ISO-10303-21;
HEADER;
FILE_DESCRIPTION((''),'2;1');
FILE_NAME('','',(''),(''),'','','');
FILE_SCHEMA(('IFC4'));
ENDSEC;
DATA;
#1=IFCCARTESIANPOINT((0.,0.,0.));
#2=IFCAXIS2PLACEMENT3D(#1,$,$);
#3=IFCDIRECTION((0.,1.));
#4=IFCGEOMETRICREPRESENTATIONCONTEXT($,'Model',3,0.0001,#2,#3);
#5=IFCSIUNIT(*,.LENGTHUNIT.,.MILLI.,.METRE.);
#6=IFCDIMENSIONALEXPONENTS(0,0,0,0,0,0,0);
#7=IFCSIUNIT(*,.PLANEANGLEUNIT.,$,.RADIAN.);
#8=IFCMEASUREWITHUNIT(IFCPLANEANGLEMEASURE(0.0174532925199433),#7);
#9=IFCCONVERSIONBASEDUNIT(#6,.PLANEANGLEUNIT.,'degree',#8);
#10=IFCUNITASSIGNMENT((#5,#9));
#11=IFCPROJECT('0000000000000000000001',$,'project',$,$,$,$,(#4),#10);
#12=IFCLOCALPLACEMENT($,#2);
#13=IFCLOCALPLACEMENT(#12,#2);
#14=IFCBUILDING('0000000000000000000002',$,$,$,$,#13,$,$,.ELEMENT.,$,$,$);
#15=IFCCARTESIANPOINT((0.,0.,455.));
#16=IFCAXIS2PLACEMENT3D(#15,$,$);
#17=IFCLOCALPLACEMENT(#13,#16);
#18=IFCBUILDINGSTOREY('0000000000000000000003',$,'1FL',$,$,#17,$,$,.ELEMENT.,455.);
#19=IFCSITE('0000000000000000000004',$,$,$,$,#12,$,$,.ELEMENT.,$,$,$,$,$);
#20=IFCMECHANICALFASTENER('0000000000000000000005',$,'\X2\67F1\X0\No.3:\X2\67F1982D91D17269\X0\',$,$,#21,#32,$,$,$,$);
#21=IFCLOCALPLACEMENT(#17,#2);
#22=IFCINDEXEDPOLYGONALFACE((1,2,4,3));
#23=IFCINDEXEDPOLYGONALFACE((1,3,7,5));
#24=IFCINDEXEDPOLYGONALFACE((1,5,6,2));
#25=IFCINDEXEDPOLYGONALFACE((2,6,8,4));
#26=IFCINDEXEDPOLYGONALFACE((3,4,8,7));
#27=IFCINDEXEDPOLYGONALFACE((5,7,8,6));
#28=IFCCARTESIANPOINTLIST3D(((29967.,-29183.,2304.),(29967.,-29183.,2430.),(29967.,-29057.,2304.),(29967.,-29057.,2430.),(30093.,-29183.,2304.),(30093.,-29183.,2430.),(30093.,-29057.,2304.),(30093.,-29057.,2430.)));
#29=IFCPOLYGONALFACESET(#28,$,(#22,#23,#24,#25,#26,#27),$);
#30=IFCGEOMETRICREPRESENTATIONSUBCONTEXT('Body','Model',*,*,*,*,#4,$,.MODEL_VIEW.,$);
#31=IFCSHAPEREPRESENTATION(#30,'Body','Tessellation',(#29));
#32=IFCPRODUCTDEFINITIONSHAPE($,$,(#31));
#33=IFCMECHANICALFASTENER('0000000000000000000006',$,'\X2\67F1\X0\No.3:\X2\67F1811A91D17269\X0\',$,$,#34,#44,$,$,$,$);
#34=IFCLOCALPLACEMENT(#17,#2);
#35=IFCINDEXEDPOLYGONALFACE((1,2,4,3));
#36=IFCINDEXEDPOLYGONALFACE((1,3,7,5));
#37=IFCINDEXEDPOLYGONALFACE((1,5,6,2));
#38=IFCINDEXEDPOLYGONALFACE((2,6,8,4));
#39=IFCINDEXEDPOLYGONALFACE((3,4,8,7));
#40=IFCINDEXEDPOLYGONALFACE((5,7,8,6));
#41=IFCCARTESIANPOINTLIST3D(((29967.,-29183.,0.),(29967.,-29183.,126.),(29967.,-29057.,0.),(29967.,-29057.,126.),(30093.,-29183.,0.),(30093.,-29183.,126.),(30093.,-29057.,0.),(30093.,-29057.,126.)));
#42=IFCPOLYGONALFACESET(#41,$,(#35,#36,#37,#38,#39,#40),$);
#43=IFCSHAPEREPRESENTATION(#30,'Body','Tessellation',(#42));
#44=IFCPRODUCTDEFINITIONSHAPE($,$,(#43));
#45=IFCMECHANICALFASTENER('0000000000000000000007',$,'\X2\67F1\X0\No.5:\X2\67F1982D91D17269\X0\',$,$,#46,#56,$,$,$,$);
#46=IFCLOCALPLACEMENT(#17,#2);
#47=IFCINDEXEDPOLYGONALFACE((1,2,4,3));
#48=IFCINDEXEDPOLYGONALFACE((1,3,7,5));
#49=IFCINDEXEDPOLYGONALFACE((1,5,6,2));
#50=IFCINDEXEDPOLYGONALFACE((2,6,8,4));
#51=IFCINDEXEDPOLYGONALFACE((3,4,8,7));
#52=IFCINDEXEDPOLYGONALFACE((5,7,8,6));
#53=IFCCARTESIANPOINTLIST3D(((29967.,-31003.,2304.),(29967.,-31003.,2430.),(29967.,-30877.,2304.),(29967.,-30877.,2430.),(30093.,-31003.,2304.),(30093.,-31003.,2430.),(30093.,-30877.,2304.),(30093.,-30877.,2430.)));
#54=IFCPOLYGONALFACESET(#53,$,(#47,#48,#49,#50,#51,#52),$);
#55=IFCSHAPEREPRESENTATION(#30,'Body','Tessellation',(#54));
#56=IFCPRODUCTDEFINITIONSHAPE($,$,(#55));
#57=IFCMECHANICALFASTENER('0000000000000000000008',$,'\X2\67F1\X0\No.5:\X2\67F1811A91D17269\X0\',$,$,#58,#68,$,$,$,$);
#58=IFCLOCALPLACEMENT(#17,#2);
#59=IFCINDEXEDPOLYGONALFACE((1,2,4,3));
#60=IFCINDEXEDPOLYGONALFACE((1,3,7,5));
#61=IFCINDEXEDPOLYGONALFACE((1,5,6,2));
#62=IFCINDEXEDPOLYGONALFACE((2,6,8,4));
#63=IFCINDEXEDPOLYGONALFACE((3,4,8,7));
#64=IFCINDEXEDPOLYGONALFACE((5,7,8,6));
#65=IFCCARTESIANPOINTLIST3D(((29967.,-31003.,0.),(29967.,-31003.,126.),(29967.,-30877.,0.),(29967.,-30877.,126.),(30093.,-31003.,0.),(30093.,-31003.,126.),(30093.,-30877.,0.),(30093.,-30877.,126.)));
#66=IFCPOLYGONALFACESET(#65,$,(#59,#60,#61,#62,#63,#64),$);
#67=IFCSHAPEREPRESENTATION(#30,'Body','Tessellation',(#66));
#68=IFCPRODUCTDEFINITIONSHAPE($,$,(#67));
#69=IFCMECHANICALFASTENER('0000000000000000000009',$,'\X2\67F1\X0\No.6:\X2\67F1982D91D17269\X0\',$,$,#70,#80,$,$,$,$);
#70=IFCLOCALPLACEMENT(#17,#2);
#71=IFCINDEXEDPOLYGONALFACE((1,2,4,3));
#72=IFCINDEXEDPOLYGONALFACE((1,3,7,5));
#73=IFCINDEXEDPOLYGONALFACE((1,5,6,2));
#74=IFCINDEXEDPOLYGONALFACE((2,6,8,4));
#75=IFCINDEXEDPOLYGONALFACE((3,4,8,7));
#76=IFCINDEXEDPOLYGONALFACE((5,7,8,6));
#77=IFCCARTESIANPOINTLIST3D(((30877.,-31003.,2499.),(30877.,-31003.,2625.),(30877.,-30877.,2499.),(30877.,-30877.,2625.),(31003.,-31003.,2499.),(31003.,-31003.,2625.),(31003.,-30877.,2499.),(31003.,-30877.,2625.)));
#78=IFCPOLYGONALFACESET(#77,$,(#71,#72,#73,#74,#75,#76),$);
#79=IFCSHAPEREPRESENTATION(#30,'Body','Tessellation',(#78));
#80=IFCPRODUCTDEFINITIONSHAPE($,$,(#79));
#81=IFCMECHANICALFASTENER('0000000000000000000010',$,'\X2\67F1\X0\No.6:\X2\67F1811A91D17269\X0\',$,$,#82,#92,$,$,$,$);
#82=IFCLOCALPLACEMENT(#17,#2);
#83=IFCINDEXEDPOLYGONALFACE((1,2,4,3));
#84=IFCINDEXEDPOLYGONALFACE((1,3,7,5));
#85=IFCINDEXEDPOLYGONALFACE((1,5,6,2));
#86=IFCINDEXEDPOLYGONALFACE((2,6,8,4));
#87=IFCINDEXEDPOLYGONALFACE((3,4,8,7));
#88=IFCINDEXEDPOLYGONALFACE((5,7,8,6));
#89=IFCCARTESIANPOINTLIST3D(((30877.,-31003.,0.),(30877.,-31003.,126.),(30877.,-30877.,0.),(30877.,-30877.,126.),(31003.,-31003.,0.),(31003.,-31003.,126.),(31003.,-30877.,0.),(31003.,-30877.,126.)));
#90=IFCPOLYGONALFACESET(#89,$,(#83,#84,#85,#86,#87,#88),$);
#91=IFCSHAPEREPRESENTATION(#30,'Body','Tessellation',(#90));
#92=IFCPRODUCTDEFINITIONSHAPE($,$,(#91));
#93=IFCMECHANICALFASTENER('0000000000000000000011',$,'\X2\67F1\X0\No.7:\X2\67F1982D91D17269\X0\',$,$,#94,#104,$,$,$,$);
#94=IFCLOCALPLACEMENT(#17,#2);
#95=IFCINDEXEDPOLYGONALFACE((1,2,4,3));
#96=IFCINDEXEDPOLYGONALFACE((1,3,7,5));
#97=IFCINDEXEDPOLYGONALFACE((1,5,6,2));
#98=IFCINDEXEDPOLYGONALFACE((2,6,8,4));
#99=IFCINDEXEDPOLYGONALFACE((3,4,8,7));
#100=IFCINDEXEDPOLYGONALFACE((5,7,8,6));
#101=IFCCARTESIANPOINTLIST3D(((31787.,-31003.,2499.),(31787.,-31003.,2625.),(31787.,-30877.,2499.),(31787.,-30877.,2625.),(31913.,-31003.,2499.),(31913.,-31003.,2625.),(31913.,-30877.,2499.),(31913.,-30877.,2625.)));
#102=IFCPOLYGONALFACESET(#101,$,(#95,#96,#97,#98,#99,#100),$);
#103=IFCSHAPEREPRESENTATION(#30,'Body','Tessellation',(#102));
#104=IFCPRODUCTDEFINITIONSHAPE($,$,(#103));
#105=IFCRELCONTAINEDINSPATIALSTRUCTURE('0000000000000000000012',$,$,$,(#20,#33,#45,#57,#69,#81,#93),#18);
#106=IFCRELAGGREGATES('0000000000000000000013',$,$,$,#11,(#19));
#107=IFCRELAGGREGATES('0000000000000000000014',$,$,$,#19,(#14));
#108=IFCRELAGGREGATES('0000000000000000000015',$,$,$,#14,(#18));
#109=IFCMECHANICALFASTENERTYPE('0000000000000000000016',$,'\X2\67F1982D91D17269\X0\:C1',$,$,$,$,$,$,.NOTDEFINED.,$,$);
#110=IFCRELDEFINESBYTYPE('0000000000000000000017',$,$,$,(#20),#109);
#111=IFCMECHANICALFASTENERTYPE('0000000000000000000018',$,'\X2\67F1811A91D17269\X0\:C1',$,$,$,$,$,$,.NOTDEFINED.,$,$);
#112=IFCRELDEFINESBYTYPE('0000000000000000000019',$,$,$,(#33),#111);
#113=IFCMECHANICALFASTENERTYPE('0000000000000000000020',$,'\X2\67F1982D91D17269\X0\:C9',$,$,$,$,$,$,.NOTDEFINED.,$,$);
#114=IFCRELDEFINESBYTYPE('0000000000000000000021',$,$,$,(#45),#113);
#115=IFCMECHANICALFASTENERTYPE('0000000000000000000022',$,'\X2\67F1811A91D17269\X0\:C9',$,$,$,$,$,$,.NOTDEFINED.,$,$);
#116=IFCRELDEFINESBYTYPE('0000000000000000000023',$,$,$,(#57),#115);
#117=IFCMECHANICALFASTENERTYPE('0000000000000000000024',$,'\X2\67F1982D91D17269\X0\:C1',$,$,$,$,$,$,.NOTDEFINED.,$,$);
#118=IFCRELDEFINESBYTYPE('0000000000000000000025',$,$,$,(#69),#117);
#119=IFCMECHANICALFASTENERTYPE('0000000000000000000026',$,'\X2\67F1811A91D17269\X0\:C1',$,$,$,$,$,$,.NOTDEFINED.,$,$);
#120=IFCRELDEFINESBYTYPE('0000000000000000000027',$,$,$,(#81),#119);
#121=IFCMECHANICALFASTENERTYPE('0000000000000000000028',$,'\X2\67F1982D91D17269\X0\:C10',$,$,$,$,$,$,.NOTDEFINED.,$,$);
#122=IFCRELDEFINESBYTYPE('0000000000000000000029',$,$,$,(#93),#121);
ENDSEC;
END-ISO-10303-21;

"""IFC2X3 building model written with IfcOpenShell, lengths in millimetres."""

from ifc_helpers import new_model, entity, si_unit, converted_unit, direction, frame, origin, origin_with_axes, origin_2d, place, context, subcontext, project, spatial, rectangle, extrude, type_object, element, save


model = new_model("IFC2X3")

# Units and contexts
model_context = context("Model", 3, precision=0.0001, world=origin(), true_north=direction((0.0, 1.0)))
body_context = subcontext(model_context, "Body", "Model", "MODEL_VIEW")
ifc_project = project(units=[si_unit("LENGTHUNIT", "METRE", prefix="MILLI"), converted_unit("PLANEANGLEUNIT", "degree", entity("IfcPlaneAngleMeasure", 0.0174532925199433), si_unit("PLANEANGLEUNIT", "RADIAN"), dimensions=[0, 0, 0, 0, 0, 0, 0])], contexts=[model_context])

# Site, building, storey
site_placement = place(None, origin())
site = spatial("IfcSite", under=ifc_project, at=site_placement, CompositionType="ELEMENT")
building_placement = place(site_placement, origin())
building = spatial("IfcBuilding", under=site, at=building_placement, CompositionType="ELEMENT")
storey_placement = place(building_placement, frame((0.0, 0.0, 455.0)))
storey = spatial("IfcBuildingStorey", under=building, at=storey_placement, Name="1FL", CompositionType="ELEMENT", Elevation=455.0)

# Mechanical fasteners
mechanical_fastener_type_1 = type_object("IfcMechanicalFastenerType", Name="柱頭金物:C1")
mechanical_fastener_1_placement = place(storey_placement, frame((30030.0, -29120.0, 2304.0)))
element("IfcMechanicalFastener", 1, at=mechanical_fastener_1_placement, inside=storey, type_object=mechanical_fastener_type_1, Name="柱No.3:柱頭金物", context=body_context, shape_type="SweptSolid", body=[
    extrude(rectangle(XDim=126.0, YDim=126.0, at=origin_2d()), origin_with_axes(), (0.0, 0.0, 1.0), 126.0),
])
mechanical_fastener_type_2 = type_object("IfcMechanicalFastenerType", Name="柱脚金物:C1")
mechanical_fastener_2_placement = place(storey_placement, frame((30030.0, -29120.0, 0.0)))
element("IfcMechanicalFastener", 2, at=mechanical_fastener_2_placement, inside=storey, type_object=mechanical_fastener_type_2, Name="柱No.3:柱脚金物", context=body_context, shape_type="SweptSolid", body=[
    extrude(rectangle(XDim=126.0, YDim=126.0, at=origin_2d()), origin_with_axes(), (0.0, 0.0, 1.0), 126.0),
])
mechanical_fastener_type_3 = type_object("IfcMechanicalFastenerType", Name="柱頭金物:C9")
mechanical_fastener_3_placement = place(storey_placement, frame((30030.0, -30940.0, 2304.0)))
element("IfcMechanicalFastener", 3, at=mechanical_fastener_3_placement, inside=storey, type_object=mechanical_fastener_type_3, Name="柱No.5:柱頭金物", context=body_context, shape_type="SweptSolid", body=[
    extrude(rectangle(XDim=126.0, YDim=126.0, at=origin_2d()), origin_with_axes(), (0.0, 0.0, 1.0), 126.0),
])
mechanical_fastener_type_4 = type_object("IfcMechanicalFastenerType", Name="柱脚金物:C9")
mechanical_fastener_4_placement = place(storey_placement, frame((30030.0, -30940.0, 0.0)))
element("IfcMechanicalFastener", 4, at=mechanical_fastener_4_placement, inside=storey, type_object=mechanical_fastener_type_4, Name="柱No.5:柱脚金物", context=body_context, shape_type="SweptSolid", body=[
    extrude(rectangle(XDim=126.0, YDim=126.0, at=origin_2d()), origin_with_axes(), (0.0, 0.0, 1.0), 126.0),
])
mechanical_fastener_type_5 = type_object("IfcMechanicalFastenerType", Name="柱頭金物:C1")
mechanical_fastener_5_placement = place(storey_placement, frame((30940.0, -30940.0, 2499.0)))
element("IfcMechanicalFastener", 5, at=mechanical_fastener_5_placement, inside=storey, type_object=mechanical_fastener_type_5, Name="柱No.6:柱頭金物", context=body_context, shape_type="SweptSolid", body=[
    extrude(rectangle(XDim=126.0, YDim=126.0, at=origin_2d()), origin_with_axes(), (0.0, 0.0, 1.0), 126.0),
])
mechanical_fastener_type_6 = type_object("IfcMechanicalFastenerType", Name="柱脚金物:C1")
mechanical_fastener_6_placement = place(storey_placement, frame((30940.0, -30940.0, 0.0)))
element("IfcMechanicalFastener", 6, at=mechanical_fastener_6_placement, inside=storey, type_object=mechanical_fastener_type_6, Name="柱No.6:柱脚金物", context=body_context, shape_type="SweptSolid", body=[
    extrude(rectangle(XDim=126.0, YDim=126.0, at=origin_2d()), origin_with_axes(), (0.0, 0.0, 1.0), 126.0),
])
mechanical_fastener_type_7 = type_object("IfcMechanicalFastenerType", Name="柱頭金物:C10")
mechanical_fastener_7_placement = place(storey_placement, frame((31850.0, -30940.0, 2499.0)))
element("IfcMechanicalFastener", 7, at=mechanical_fastener_7_placement, inside=storey, type_object=mechanical_fastener_type_7, Name="柱No.7:柱頭金物", context=body_context, shape_type="SweptSolid", body=[
    extrude(rectangle(XDim=126.0, YDim=126.0, at=origin_2d()), origin_with_axes(), (0.0, 0.0, 1.0), 126.0),
])

save(model, "model.ifc")
